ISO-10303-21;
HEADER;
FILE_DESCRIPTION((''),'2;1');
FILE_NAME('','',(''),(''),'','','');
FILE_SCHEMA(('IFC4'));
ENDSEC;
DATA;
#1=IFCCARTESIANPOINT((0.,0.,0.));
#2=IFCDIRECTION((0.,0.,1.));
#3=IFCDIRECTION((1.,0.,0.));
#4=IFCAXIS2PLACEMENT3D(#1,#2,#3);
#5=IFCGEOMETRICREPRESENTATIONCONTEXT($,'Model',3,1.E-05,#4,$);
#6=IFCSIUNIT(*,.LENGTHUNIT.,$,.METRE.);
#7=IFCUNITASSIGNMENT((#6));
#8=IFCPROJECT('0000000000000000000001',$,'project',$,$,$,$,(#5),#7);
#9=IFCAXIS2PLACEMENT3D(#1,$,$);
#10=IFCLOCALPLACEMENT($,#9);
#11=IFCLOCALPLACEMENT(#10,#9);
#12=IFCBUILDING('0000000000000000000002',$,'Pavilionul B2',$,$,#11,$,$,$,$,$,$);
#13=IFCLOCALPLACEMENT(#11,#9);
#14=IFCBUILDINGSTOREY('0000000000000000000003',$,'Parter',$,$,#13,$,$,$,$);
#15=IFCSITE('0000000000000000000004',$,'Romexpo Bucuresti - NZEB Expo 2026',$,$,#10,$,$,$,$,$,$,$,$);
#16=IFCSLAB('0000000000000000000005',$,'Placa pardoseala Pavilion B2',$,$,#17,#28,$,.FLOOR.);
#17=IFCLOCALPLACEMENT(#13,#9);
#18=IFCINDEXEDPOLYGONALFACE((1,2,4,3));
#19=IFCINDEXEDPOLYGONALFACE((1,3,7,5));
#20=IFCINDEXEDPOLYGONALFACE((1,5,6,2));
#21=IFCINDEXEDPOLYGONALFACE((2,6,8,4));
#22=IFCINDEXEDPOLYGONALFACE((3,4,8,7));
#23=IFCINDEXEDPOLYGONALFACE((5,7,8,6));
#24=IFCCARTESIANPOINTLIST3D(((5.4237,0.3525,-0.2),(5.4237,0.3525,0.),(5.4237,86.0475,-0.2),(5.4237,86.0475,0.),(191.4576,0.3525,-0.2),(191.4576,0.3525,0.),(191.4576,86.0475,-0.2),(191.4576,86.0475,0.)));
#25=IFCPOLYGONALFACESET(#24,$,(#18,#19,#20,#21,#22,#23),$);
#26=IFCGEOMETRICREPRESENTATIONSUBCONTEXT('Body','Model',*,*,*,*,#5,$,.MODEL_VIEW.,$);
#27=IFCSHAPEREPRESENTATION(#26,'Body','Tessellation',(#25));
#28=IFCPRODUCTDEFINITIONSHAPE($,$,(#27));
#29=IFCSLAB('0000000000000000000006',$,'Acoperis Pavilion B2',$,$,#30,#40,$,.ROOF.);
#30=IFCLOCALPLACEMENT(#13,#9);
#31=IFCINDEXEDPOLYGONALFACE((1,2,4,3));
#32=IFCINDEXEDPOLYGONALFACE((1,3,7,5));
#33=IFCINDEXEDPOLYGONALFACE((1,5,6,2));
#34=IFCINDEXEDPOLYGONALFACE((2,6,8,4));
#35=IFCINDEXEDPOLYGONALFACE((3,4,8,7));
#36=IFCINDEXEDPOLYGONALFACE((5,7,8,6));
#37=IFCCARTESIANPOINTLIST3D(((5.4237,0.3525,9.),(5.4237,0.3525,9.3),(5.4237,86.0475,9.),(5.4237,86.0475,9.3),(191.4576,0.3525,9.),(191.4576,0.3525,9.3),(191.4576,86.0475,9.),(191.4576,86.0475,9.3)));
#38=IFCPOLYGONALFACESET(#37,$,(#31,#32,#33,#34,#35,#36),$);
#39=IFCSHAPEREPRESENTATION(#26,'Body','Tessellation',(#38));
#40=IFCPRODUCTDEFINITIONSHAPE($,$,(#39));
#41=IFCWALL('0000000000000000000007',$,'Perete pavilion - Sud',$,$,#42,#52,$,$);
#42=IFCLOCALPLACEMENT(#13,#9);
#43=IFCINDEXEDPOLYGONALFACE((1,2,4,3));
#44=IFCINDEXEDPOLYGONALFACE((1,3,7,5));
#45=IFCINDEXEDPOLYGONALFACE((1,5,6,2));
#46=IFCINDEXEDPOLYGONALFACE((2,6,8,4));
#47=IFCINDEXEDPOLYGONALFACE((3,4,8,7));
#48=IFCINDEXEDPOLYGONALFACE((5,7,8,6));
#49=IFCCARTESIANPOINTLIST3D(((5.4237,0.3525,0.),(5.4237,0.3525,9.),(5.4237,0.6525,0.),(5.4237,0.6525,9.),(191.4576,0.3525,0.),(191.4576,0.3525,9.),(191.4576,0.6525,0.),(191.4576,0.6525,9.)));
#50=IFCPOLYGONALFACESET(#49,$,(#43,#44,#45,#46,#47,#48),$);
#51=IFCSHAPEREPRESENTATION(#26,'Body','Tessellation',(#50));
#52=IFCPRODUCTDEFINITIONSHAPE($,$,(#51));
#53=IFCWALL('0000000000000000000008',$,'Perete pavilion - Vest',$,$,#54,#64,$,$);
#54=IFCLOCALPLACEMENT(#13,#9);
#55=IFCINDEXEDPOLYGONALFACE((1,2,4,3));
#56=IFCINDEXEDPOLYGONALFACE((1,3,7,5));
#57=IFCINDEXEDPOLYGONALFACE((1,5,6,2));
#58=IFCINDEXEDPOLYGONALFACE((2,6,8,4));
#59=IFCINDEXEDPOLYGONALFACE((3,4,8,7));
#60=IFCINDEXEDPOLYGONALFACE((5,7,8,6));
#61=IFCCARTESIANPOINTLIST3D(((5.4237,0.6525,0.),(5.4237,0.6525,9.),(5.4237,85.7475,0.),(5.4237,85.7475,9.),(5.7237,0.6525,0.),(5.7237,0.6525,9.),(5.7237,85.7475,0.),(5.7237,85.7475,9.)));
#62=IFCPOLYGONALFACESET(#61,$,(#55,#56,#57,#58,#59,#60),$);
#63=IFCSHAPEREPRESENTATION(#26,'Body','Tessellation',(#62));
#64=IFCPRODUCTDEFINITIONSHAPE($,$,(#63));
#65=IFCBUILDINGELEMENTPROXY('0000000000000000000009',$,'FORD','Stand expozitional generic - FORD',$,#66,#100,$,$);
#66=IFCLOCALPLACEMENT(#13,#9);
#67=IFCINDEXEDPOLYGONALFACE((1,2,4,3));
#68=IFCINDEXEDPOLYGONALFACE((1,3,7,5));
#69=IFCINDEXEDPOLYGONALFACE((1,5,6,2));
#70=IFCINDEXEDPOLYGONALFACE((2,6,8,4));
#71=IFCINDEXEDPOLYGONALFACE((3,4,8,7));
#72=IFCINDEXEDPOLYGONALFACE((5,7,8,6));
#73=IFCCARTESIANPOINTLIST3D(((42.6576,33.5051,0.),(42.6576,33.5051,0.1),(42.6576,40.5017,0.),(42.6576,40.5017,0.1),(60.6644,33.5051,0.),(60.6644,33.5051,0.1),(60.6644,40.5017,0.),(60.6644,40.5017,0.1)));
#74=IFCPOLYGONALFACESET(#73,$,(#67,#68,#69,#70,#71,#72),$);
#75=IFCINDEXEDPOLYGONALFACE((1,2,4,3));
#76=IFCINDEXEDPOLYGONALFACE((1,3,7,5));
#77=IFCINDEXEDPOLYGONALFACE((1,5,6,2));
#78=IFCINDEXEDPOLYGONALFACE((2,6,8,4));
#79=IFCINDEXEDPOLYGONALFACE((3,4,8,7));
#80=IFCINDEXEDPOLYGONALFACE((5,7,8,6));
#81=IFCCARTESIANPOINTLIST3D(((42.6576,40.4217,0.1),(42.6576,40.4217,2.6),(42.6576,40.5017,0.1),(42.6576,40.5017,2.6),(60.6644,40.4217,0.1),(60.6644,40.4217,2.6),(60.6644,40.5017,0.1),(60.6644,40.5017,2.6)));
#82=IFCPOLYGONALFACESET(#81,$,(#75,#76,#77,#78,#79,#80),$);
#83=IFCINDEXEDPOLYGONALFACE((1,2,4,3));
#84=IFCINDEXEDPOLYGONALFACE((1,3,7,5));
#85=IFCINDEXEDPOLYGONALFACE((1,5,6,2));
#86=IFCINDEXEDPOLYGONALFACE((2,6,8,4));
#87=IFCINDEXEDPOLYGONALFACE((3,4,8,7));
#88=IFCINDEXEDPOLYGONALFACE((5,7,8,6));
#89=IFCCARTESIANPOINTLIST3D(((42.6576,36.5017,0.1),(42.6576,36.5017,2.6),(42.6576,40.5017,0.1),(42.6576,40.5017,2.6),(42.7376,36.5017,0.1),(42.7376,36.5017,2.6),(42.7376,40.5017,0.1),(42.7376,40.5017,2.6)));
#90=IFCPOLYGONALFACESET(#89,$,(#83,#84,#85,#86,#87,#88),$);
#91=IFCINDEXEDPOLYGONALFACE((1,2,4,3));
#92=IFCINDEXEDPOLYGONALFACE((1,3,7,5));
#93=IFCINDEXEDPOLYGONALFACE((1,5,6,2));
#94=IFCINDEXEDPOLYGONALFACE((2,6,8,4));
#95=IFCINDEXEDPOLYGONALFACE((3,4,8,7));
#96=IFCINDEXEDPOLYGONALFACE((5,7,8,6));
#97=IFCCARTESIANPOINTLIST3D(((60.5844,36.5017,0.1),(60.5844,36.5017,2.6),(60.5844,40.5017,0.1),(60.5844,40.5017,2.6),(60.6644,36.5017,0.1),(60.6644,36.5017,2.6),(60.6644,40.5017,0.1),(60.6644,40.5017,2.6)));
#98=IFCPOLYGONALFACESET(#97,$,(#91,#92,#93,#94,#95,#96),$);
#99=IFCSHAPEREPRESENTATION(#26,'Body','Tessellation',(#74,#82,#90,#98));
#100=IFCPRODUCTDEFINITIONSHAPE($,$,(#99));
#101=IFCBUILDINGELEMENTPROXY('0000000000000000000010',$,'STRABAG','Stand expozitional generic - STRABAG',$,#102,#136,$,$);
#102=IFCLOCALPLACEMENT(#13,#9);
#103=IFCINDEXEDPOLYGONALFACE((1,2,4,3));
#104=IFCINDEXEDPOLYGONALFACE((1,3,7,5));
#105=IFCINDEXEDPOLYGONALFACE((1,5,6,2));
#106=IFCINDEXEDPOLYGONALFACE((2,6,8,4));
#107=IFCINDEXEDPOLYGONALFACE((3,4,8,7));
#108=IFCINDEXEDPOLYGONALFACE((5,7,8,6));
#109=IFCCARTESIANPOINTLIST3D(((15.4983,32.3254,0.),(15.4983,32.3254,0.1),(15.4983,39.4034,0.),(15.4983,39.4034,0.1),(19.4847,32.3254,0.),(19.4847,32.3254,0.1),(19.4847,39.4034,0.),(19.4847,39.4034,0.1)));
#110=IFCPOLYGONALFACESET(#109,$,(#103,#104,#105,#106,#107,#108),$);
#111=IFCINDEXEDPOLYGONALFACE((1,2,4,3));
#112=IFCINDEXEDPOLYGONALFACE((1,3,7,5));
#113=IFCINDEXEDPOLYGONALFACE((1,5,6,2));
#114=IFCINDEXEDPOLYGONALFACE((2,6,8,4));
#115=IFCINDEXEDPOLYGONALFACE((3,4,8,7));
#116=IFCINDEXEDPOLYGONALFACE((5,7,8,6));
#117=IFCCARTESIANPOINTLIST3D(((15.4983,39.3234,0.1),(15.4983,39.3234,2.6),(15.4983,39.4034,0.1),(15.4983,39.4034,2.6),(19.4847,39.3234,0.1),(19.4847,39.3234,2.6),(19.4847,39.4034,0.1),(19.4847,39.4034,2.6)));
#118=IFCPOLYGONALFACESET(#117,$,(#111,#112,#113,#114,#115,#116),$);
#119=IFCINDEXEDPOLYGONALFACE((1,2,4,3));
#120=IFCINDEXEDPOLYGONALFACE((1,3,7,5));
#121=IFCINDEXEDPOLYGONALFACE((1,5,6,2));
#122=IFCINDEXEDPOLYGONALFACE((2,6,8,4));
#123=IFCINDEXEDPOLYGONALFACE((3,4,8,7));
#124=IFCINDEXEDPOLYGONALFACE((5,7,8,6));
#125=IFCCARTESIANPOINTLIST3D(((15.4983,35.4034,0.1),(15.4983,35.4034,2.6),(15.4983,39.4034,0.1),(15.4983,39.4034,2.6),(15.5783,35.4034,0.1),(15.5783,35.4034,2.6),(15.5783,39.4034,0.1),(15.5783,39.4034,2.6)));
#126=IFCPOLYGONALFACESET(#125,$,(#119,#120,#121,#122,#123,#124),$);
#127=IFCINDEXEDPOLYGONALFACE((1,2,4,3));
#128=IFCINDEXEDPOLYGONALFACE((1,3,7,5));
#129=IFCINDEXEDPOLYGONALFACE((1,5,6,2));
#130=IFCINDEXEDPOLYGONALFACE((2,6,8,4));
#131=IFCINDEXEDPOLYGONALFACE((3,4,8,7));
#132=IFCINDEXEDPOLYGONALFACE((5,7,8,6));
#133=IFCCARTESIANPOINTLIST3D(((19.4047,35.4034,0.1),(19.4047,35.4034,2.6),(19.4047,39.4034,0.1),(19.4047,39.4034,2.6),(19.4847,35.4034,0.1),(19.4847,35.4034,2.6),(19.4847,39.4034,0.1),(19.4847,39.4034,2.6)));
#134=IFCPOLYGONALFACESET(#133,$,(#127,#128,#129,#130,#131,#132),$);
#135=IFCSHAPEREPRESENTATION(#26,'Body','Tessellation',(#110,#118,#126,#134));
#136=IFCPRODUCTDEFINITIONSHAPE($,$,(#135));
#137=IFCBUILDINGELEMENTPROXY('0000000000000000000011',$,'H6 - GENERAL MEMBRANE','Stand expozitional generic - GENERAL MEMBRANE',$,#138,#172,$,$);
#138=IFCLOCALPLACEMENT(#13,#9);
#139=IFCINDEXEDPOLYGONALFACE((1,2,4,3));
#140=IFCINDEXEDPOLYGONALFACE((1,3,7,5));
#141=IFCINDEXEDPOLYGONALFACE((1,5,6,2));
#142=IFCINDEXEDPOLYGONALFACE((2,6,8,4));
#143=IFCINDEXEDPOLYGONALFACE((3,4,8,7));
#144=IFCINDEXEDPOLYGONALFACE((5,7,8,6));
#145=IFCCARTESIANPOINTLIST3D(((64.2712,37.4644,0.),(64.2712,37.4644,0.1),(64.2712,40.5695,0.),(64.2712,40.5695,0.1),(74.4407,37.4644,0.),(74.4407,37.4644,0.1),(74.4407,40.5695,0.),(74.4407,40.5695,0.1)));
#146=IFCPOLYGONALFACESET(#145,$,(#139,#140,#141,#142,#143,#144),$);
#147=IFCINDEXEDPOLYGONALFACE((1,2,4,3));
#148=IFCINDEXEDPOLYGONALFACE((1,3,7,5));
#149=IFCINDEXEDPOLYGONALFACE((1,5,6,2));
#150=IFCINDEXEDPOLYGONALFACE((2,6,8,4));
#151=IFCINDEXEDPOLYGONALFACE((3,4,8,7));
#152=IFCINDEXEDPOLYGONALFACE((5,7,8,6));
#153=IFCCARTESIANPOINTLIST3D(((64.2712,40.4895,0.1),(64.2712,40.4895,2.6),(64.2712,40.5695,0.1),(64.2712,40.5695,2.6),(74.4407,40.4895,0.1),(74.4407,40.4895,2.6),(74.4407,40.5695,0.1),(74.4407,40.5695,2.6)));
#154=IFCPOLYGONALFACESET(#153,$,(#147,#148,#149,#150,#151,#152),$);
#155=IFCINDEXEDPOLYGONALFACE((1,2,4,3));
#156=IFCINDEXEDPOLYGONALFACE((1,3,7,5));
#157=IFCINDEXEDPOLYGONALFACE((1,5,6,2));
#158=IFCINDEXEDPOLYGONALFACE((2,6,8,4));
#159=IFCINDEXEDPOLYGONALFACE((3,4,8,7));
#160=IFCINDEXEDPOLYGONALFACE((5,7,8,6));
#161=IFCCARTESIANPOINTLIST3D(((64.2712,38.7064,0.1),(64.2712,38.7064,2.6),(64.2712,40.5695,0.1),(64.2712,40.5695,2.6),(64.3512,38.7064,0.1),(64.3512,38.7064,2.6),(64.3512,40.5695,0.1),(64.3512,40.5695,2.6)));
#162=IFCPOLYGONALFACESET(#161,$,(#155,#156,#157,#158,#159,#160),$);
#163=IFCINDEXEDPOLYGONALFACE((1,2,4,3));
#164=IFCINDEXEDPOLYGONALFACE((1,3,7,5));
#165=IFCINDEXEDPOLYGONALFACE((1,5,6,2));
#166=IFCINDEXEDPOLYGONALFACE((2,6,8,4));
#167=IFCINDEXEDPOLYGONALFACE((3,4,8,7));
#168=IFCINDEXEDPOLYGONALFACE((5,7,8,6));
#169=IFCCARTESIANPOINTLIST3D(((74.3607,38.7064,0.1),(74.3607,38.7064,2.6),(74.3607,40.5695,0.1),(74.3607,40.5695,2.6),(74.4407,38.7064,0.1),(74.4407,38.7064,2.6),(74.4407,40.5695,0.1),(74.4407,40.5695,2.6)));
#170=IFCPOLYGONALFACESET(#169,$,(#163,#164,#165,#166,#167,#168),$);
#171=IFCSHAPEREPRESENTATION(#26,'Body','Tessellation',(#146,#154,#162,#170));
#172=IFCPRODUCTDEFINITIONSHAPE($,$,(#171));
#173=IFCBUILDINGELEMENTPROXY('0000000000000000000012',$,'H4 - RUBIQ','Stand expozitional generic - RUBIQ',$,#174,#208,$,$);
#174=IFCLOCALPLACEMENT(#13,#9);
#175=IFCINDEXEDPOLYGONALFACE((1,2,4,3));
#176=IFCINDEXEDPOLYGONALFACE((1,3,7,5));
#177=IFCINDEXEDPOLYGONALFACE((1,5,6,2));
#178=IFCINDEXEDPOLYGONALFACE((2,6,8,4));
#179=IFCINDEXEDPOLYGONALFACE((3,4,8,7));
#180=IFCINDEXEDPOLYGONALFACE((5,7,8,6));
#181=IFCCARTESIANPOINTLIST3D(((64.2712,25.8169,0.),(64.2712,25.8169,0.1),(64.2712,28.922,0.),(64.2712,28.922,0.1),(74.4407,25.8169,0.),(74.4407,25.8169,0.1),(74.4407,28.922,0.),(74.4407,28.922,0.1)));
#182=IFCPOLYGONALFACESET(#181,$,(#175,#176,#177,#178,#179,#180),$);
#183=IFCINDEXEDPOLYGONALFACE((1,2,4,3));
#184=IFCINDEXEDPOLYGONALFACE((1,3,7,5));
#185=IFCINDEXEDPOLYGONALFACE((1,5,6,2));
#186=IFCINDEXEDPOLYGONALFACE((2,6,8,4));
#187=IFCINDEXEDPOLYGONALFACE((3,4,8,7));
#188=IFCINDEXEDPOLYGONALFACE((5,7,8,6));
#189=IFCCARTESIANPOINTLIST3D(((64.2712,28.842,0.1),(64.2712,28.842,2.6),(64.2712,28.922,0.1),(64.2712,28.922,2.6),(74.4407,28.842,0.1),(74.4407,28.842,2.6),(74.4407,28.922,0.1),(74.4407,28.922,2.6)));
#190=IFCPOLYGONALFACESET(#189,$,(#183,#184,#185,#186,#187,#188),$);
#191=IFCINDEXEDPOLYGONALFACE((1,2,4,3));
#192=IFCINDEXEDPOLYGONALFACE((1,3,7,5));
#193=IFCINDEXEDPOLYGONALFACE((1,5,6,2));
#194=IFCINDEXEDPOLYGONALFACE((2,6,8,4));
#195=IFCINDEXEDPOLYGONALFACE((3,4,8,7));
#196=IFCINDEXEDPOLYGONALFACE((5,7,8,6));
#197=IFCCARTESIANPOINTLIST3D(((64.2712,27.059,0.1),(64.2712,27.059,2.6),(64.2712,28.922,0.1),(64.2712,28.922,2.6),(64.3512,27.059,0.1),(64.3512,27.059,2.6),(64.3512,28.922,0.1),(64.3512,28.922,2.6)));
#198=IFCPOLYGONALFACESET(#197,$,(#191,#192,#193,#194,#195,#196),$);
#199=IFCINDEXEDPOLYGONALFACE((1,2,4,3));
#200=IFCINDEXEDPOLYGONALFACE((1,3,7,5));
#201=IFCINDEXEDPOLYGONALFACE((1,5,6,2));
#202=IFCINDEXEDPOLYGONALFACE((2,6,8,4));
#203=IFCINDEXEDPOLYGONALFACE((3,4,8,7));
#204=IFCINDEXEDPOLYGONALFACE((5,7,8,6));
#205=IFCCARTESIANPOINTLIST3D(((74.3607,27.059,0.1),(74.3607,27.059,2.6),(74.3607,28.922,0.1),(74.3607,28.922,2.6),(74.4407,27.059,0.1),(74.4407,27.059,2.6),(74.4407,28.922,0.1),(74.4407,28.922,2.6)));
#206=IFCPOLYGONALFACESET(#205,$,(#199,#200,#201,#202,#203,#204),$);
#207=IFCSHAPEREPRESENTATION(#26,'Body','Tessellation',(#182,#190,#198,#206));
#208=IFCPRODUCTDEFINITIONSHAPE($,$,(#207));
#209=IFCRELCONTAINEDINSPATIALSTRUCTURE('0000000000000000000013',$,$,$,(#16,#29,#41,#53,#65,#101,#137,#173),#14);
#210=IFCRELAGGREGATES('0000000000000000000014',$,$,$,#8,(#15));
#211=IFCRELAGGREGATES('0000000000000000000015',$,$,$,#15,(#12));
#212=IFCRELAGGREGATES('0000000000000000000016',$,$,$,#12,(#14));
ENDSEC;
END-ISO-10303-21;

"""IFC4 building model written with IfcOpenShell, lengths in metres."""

from ifc_helpers import new_model, si_unit, frame, frame_2d, origin, origin_with_axes, place, context, subcontext, project, spatial, rectangle, extrude, element, save


model = new_model("IFC4")

# Units and contexts
model_context = context("Model", 3, precision=1e-05, world=origin_with_axes())
body_context = subcontext(model_context, "Body", "Model", "MODEL_VIEW")
ifc_project = project(units=[si_unit("LENGTHUNIT", "METRE")], contexts=[model_context])

# Site, building, storey
site_placement = place(None, origin())
site = spatial("IfcSite", under=ifc_project, at=site_placement, Name="Romexpo Bucuresti - NZEB Expo 2026")
building_placement = place(site_placement, origin())
building = spatial("IfcBuilding", under=site, at=building_placement, Name="Pavilionul B2")
storey_placement = place(building_placement, origin())
storey = spatial("IfcBuildingStorey", under=building, at=storey_placement, Name="Parter")

# Slabs
slab_1_placement = place(storey_placement, frame((5.4237, 0.3525, 0.0), z_axis=(0.0, 0.0, 1.0), x_axis=(1.0, 0.0, 0.0)))
element("IfcSlab", 1, at=slab_1_placement, inside=storey, Name="Placa pardoseala Pavilion B2", PredefinedType="FLOOR", context=body_context, shape_type="SweptSolid", body=[
    extrude(rectangle(XDim=186.0339, YDim=85.6949, at=frame_2d((93.0169, 42.8475))), frame((0.0, 0.0, -0.2)), (0.0, 0.0, 1.0), 0.2),
])
slab_2_placement = place(storey_placement, frame((5.4237, 0.3525, 0.0), z_axis=(0.0, 0.0, 1.0), x_axis=(1.0, 0.0, 0.0)))
element("IfcSlab", 2, at=slab_2_placement, inside=storey, Name="Acoperis Pavilion B2", PredefinedType="ROOF", context=body_context, shape_type="SweptSolid", body=[
    extrude(rectangle(XDim=186.0339, YDim=85.6949, at=frame_2d((93.0169, 42.8475))), frame((0.0, 0.0, 9.0)), (0.0, 0.0, 1.0), 0.3),
])

# Walls
wall_1_placement = place(storey_placement, frame((5.4237, 0.3525, 0.0), z_axis=(0.0, 0.0, 1.0), x_axis=(1.0, 0.0, 0.0)))
element("IfcWall", 3, at=wall_1_placement, inside=storey, Name="Perete pavilion - Sud", context=body_context, shape_type="SweptSolid", body=[
    extrude(rectangle(XDim=186.0339, YDim=0.3, at=frame_2d((93.0169, 0.15))), origin(), (0.0, 0.0, 1.0), 9.0),
])
wall_2_placement = place(storey_placement, frame((5.4237, 0.6525, 0.0), z_axis=(0.0, 0.0, 1.0), x_axis=(1.0, 0.0, 0.0)))
element("IfcWall", 4, at=wall_2_placement, inside=storey, Name="Perete pavilion - Vest", context=body_context, shape_type="SweptSolid", body=[
    extrude(rectangle(XDim=0.3, YDim=85.0949, at=frame_2d((0.15, 42.5475))), origin(), (0.0, 0.0, 1.0), 9.0),
])

# Building element proxies
proxy_1_placement = place(storey_placement, frame((42.6576, 33.5051, 0.0), z_axis=(0.0, 0.0, 1.0), x_axis=(1.0, 0.0, 0.0)))
element("IfcBuildingElementProxy", 5, at=proxy_1_placement, inside=storey, Name="FORD", Description="Stand expozitional generic - FORD", context=body_context, shape_type="SweptSolid", body=[
    extrude(rectangle(XDim=18.0068, YDim=6.9966, at=frame_2d((9.0034, 3.4983))), origin(), (0.0, 0.0, 1.0), 0.1),
    extrude(rectangle(XDim=18.0068, YDim=0.08, at=frame_2d((9.0034, 6.9566))), frame((0.0, 0.0, 0.1)), (0.0, 0.0, 1.0), 2.5),
    extrude(rectangle(XDim=0.08, YDim=4.0, at=frame_2d((0.04, 4.9966))), frame((0.0, 0.0, 0.1)), (0.0, 0.0, 1.0), 2.5),
    extrude(rectangle(XDim=0.08, YDim=4.0, at=frame_2d((17.9668, 4.9966))), frame((0.0, 0.0, 0.1)), (0.0, 0.0, 1.0), 2.5),
])
proxy_2_placement = place(storey_placement, frame((15.4983, 32.3254, 0.0), z_axis=(0.0, 0.0, 1.0), x_axis=(1.0, 0.0, 0.0)))
element("IfcBuildingElementProxy", 6, at=proxy_2_placement, inside=storey, Name="STRABAG", Description="Stand expozitional generic - STRABAG", context=body_context, shape_type="SweptSolid", body=[
    extrude(rectangle(XDim=3.9864, YDim=7.078, at=frame_2d((1.9932, 3.539))), origin(), (0.0, 0.0, 1.0), 0.1),
    extrude(rectangle(XDim=3.9864, YDim=0.08, at=frame_2d((1.9932, 7.038))), frame((0.0, 0.0, 0.1)), (0.0, 0.0, 1.0), 2.5),
    extrude(rectangle(XDim=0.08, YDim=4.0, at=frame_2d((0.04, 5.078))), frame((0.0, 0.0, 0.1)), (0.0, 0.0, 1.0), 2.5),
    extrude(rectangle(XDim=0.08, YDim=4.0, at=frame_2d((3.9464, 5.078))), frame((0.0, 0.0, 0.1)), (0.0, 0.0, 1.0), 2.5),
])
for number, where, z_axis, x_axis, name, description in (
    (7, (64.2712, 37.4644, 0.0), (0.0, 0.0, 1.0), (1.0, 0.0, 0.0), "H6 - GENERAL MEMBRANE", "Stand expozitional generic - GENERAL MEMBRANE"),
    (8, (64.2712, 25.8169, 0.0), (0.0, 0.0, 1.0), (1.0, 0.0, 0.0), "H4 - RUBIQ", "Stand expozitional generic - RUBIQ"),
):
    element("IfcBuildingElementProxy", number, at=place(storey_placement, frame(where, z_axis=z_axis, x_axis=x_axis)), inside=storey, Name=name, Description=description, context=body_context, shape_type="SweptSolid", body=[
        extrude(rectangle(XDim=10.1695, YDim=3.1051, at=frame_2d((5.0847, 1.5525))), origin(), (0.0, 0.0, 1.0), 0.1),
        extrude(rectangle(XDim=10.1695, YDim=0.08, at=frame_2d((5.0847, 3.0651))), frame((0.0, 0.0, 0.1)), (0.0, 0.0, 1.0), 2.5),
        extrude(rectangle(XDim=0.08, YDim=1.8631, at=frame_2d((0.04, 2.1736))), frame((0.0, 0.0, 0.1)), (0.0, 0.0, 1.0), 2.5),
        extrude(rectangle(XDim=0.08, YDim=1.8631, at=frame_2d((10.1295, 2.1736))), frame((0.0, 0.0, 0.1)), (0.0, 0.0, 1.0), 2.5),
    ])

save(model, "model.ifc")
